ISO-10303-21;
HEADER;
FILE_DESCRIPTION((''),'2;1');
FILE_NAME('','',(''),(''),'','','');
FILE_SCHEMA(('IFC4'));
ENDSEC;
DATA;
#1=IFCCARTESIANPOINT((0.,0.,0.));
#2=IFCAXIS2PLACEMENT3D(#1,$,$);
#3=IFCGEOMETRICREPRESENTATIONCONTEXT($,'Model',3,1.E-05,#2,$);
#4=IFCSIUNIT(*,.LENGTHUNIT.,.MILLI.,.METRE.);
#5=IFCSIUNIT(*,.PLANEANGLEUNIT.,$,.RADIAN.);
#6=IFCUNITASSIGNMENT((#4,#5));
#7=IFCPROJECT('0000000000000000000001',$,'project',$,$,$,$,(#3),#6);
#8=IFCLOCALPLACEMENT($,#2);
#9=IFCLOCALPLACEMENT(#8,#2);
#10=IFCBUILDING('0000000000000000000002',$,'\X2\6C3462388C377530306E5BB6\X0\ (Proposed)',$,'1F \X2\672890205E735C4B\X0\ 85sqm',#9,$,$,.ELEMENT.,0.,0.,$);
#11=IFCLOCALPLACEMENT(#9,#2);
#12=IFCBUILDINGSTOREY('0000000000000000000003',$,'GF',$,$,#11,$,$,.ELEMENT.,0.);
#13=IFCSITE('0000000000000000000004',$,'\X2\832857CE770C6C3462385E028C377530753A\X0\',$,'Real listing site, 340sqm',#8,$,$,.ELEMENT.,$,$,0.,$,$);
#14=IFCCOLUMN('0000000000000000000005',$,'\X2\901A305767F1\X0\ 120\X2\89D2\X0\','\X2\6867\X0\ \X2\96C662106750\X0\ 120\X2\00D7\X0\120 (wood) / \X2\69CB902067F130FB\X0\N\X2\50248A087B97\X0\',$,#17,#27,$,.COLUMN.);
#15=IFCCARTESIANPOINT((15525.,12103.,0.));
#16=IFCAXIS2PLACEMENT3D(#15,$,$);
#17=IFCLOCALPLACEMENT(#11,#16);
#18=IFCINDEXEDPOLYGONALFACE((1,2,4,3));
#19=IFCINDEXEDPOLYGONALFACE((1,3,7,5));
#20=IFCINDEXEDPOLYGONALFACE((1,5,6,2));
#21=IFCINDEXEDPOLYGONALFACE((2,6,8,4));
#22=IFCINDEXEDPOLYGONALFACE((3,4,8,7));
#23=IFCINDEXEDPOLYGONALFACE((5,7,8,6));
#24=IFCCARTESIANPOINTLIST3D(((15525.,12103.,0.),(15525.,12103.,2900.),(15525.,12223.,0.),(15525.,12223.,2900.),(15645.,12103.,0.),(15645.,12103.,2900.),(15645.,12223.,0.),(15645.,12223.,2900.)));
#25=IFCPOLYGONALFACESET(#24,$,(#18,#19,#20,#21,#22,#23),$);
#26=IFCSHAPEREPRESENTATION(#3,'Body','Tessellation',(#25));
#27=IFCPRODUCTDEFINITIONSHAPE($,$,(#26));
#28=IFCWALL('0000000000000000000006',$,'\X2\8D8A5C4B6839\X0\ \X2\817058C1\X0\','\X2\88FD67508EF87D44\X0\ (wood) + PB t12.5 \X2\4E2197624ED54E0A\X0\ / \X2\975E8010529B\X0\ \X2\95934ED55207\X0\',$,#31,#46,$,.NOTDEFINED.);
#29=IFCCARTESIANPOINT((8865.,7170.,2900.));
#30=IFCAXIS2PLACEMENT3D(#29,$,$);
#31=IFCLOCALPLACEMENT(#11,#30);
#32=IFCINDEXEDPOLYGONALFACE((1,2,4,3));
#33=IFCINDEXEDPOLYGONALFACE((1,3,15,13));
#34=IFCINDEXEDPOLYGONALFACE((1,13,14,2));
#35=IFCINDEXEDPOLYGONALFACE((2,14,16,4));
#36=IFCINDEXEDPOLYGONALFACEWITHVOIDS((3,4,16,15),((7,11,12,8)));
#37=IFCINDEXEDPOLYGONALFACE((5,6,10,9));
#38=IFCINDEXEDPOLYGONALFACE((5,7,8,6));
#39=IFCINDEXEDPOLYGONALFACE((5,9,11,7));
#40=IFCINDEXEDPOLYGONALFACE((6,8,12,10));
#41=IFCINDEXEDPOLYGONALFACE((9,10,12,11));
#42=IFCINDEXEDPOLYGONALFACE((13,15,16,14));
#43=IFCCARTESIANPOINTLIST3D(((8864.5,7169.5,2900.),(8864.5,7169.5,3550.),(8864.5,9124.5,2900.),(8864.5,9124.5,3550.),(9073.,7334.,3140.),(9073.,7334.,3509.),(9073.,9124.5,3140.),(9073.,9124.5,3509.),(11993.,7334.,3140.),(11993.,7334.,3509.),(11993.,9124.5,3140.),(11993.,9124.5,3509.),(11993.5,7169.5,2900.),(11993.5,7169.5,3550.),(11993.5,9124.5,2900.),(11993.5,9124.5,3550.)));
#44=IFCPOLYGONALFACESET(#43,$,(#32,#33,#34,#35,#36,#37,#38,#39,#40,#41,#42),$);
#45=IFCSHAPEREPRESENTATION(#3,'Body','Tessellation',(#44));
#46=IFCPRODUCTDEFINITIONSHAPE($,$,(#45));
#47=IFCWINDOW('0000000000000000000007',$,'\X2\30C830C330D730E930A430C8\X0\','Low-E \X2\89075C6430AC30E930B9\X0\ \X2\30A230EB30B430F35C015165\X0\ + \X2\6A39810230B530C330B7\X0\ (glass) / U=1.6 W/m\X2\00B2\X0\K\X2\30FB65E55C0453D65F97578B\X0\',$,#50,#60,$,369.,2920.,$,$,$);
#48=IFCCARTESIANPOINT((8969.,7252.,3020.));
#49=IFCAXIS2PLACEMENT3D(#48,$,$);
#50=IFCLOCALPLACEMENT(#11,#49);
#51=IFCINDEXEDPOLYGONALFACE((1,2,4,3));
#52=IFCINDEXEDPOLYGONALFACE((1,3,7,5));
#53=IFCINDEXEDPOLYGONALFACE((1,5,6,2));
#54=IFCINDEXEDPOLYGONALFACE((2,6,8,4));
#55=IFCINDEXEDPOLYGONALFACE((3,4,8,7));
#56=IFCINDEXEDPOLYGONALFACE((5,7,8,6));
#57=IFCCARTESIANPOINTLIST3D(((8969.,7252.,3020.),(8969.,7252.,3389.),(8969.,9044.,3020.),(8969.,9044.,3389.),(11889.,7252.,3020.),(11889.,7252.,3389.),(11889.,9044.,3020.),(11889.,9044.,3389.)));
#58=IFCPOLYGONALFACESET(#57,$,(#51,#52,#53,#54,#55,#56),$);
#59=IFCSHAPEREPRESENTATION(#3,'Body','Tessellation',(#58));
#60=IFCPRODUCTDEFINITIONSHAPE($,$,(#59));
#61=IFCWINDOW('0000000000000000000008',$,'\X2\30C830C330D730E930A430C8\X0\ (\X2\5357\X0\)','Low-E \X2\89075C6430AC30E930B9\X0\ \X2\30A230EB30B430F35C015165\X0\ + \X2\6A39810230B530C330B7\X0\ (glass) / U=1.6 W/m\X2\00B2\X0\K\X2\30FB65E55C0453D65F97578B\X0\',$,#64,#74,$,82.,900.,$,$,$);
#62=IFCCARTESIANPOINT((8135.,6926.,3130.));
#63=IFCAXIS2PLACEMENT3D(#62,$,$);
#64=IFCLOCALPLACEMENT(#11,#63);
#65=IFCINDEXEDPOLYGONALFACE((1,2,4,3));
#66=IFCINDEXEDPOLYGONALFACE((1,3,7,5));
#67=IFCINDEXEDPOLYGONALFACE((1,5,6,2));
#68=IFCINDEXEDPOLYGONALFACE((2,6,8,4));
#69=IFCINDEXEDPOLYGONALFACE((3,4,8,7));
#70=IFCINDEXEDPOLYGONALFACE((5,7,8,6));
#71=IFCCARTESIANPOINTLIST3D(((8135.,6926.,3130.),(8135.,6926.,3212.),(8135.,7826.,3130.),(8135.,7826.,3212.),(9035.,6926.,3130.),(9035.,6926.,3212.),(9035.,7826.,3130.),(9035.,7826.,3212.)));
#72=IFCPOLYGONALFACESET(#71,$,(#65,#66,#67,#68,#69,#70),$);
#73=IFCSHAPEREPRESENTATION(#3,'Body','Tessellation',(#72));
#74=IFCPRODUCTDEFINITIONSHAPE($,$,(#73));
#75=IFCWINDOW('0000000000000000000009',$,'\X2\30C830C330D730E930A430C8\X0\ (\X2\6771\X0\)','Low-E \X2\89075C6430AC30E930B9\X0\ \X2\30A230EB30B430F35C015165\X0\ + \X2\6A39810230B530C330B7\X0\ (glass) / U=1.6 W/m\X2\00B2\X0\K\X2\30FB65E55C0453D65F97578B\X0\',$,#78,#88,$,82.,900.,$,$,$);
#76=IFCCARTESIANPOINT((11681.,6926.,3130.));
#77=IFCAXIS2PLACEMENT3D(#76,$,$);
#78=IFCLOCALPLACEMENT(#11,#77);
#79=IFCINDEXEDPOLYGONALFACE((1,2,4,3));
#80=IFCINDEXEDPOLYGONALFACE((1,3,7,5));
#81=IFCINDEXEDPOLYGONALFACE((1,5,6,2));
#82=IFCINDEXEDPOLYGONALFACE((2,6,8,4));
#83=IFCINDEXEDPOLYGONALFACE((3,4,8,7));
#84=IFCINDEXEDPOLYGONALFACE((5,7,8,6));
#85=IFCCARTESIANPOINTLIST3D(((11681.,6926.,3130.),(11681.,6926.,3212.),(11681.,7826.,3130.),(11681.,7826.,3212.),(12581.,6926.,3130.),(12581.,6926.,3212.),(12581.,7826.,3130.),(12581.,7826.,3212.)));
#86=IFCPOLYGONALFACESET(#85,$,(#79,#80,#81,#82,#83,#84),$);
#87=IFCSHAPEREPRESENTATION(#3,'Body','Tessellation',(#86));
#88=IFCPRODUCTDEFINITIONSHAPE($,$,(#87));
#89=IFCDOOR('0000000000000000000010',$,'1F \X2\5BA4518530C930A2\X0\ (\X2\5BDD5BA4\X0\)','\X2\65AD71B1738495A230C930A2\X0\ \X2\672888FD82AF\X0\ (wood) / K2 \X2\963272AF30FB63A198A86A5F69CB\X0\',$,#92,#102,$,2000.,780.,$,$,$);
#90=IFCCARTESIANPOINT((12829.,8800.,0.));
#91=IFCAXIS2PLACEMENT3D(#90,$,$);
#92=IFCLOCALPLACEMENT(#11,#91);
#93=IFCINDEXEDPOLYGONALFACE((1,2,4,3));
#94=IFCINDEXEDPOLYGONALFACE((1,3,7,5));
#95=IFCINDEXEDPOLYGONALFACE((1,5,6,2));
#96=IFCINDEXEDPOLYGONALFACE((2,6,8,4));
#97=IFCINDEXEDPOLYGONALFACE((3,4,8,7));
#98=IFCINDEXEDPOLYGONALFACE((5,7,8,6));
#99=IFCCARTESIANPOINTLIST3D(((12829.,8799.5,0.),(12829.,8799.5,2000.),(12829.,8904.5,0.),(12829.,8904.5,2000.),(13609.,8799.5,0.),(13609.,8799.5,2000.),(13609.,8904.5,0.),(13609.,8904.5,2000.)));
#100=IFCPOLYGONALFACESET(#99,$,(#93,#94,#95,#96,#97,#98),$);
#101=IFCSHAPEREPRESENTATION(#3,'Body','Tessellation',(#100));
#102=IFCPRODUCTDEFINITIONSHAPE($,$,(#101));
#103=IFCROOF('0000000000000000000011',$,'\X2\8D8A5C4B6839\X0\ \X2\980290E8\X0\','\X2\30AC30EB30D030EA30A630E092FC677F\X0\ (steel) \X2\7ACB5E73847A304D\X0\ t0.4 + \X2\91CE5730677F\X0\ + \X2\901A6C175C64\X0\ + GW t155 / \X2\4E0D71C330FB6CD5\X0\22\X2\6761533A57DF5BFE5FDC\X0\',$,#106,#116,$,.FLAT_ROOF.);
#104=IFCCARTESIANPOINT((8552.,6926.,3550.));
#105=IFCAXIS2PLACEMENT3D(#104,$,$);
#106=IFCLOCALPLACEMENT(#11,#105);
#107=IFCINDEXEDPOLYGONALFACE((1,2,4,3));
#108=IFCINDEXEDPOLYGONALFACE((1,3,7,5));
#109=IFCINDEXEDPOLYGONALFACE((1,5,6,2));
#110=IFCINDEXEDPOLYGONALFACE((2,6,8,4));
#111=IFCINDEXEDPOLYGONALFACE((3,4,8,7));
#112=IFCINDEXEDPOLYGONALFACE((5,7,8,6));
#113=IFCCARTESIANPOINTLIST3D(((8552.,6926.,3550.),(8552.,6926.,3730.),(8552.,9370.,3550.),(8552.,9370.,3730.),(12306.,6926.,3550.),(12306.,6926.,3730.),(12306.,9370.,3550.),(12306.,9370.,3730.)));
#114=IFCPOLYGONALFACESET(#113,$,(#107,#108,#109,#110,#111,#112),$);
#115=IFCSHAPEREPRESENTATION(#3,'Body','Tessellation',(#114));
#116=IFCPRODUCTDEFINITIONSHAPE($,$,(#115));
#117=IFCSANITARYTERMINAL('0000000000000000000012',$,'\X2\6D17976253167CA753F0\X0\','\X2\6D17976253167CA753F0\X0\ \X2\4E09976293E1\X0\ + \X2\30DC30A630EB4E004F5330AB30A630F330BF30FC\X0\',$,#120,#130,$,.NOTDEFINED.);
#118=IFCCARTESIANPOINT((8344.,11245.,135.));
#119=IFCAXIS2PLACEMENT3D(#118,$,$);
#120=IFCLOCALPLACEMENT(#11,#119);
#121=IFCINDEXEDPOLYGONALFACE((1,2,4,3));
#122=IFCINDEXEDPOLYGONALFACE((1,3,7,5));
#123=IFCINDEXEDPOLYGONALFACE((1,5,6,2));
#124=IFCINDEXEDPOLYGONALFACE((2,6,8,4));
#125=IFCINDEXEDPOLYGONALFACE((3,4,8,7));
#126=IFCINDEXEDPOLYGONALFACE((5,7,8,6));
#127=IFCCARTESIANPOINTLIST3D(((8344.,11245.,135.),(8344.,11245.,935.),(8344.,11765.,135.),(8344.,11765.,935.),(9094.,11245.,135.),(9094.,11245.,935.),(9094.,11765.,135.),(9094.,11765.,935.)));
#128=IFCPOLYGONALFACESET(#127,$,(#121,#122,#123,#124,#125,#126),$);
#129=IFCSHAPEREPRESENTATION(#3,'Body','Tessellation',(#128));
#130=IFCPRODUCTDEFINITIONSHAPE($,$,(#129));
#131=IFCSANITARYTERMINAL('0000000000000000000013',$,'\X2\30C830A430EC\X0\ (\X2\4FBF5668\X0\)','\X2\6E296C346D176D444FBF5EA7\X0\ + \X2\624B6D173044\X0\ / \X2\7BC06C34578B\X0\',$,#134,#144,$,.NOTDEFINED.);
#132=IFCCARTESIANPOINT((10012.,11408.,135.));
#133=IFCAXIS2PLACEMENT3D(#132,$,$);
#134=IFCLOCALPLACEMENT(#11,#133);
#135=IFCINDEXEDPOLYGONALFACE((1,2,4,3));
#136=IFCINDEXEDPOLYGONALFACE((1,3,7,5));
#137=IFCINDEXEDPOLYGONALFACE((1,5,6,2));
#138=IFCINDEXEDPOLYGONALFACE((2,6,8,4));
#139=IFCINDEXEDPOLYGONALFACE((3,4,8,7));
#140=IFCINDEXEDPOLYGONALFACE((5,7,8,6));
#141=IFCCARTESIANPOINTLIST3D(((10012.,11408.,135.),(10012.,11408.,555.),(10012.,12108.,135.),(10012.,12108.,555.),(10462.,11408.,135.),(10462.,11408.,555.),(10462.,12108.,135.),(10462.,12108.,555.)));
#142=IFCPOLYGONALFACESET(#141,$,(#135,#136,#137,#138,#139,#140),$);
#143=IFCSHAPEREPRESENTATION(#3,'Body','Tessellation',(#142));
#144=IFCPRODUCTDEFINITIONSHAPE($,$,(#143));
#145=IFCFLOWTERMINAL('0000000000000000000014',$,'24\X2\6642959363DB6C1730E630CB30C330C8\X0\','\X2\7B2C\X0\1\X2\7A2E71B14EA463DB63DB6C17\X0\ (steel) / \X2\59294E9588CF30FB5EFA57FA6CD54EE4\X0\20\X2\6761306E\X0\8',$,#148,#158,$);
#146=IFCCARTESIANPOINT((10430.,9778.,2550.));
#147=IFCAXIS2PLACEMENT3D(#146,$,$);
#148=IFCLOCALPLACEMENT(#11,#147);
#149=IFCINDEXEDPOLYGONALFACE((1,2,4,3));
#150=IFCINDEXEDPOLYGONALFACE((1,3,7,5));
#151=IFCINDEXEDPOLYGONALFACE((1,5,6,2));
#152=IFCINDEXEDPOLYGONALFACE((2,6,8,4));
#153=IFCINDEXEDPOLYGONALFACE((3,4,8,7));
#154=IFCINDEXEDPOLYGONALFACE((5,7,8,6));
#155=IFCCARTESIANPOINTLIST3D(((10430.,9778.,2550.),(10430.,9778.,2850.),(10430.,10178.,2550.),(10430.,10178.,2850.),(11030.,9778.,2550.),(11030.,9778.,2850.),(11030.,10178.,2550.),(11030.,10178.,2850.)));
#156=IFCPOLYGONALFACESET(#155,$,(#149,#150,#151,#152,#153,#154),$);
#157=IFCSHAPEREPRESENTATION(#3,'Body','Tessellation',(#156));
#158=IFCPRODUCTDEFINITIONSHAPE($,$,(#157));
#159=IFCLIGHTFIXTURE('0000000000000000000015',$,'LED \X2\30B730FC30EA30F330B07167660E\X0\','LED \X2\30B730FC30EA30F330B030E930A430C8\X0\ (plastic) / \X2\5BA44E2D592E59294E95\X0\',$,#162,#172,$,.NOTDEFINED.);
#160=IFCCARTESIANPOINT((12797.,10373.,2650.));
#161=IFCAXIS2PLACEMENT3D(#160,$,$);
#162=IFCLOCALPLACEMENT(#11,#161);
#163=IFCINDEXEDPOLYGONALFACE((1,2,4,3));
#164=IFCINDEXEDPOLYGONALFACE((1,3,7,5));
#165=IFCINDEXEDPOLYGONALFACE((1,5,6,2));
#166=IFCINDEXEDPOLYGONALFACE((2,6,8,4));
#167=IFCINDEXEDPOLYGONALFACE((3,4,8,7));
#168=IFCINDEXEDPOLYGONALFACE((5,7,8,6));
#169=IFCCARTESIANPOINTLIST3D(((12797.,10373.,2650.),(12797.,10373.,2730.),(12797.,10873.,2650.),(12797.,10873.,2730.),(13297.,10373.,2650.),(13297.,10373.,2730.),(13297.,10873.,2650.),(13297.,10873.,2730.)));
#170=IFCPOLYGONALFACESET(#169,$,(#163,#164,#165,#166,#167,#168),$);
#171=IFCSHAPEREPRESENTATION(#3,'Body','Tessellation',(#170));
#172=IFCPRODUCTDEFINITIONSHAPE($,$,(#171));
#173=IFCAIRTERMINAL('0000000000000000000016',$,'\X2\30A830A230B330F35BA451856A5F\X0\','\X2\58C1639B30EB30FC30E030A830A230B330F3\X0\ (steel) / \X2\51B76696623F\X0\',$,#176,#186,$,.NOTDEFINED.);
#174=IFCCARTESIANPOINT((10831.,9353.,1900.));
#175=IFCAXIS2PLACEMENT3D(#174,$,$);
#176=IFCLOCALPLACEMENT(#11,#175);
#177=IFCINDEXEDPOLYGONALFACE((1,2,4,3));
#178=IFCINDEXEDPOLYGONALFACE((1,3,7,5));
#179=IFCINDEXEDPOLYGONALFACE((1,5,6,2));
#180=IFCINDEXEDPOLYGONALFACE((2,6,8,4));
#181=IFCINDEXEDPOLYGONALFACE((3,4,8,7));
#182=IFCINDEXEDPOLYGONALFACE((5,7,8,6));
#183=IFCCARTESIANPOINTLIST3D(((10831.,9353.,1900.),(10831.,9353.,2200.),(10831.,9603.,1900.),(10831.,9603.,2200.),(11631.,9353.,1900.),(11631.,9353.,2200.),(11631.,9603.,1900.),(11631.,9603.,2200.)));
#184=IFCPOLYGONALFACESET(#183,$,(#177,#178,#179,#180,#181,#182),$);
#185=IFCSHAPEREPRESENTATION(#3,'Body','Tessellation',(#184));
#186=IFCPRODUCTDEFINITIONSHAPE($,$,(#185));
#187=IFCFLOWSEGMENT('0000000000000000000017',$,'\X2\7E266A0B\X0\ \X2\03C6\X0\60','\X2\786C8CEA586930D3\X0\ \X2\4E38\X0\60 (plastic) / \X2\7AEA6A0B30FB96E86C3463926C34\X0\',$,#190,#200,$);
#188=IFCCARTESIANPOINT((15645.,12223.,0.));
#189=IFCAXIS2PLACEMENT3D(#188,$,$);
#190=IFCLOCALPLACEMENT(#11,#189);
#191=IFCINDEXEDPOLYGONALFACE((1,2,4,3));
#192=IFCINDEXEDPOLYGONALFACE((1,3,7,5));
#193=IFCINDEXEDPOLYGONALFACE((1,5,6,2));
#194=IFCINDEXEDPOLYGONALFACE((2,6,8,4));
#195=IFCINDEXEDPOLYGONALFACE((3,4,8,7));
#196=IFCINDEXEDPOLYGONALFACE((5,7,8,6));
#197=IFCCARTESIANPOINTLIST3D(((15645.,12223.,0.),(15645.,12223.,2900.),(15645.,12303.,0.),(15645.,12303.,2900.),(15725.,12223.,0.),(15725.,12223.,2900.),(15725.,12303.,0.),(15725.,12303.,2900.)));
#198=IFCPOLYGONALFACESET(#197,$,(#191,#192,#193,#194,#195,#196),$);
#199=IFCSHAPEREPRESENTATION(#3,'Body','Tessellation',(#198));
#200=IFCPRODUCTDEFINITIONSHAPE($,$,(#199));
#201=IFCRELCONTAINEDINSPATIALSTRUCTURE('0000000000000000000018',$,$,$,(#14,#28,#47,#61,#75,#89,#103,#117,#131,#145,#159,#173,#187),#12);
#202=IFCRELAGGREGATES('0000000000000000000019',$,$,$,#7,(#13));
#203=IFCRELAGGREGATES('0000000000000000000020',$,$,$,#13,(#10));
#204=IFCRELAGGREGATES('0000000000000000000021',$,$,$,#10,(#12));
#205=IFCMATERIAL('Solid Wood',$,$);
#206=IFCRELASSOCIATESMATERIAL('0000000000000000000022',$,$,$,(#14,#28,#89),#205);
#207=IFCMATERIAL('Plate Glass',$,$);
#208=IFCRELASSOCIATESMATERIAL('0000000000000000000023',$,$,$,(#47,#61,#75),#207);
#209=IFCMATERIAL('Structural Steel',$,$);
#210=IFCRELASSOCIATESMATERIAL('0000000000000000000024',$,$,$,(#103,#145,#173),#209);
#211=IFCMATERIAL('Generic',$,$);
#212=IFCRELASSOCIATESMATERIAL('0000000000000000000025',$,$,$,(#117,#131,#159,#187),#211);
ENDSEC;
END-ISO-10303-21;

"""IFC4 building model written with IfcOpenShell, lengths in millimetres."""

from ifc_helpers import new_model, si_unit, frame, frame_2d, origin, place, context, project, spatial, rectangle, extrude, material, element, fill, save


model = new_model("IFC4")

# Units and contexts
model_context = context("Model", 3, precision=1e-05, world=origin())
ifc_project = project(units=[si_unit("LENGTHUNIT", "METRE", prefix="MILLI"), si_unit("PLANEANGLEUNIT", "RADIAN")], contexts=[model_context])

# Site, building, storey
site_placement = place(None, origin())
site = spatial("IfcSite", under=ifc_project, at=site_placement, Name="茨城県水戸市谷田町", ObjectType="Real listing site, 340sqm", CompositionType="ELEMENT", RefElevation=0.0)
building_placement = place(site_placement, origin())
building = spatial("IfcBuilding", under=site, at=building_placement, Name="水戸谷田の家 (Proposed)", ObjectType="1F 木造平屋 85sqm", CompositionType="ELEMENT", ElevationOfRefHeight=0.0, ElevationOfTerrain=0.0)
storey_placement = place(building_placement, origin())
storey = spatial("IfcBuildingStorey", under=building, at=storey_placement, Name="GF", CompositionType="ELEMENT", Elevation=0.0)

# Column
ifc_material_1 = material(Name="Solid Wood")
column_1_placement = place(storey_placement, frame((15525.0, 12103.0, 0.0)))
element("IfcColumn", 1, at=column_1_placement, inside=storey, material=ifc_material_1, Name="通し柱 120角", Description="桧 集成材 120×120 (wood) / 構造柱・N値計算", PredefinedType="COLUMN", context=model_context, shape_type="SweptSolid", body=[
    extrude(rectangle(XDim=120.0, YDim=120.0, at=frame_2d((60.0, 60.0))), frame((15525.0, 12103.0, 0.0)), (0.0, 0.0, 1.0), 2900.0),
])

# Wall, openings, windows
wall_1_placement = place(storey_placement, frame((8865.0, 7170.0, 2900.0)))
wall_1 = element("IfcWall", 2, at=wall_1_placement, inside=storey, material=ifc_material_1, Name="越屋根 腰壁", Description="製材軸組 (wood) + PB t12.5 両面仕上 / 非耐力 間仕切", PredefinedType="NOTDEFINED", context=model_context, shape_type="SweptSolid", body=[
    extrude(rectangle(XDim=3129.0, YDim=1955.0, at=frame_2d((1564.0, 977.0))), frame((8865.0, 7170.0, 2900.0)), (0.0, 0.0, 1.0), 650.0),
])
opening_1_placement = place(storey_placement, frame((8969.0, 7252.0, 3020.0)))
opening_1 = element("IfcOpeningElement", 3, at=opening_1_placement, cuts=wall_1, PredefinedType="NOTDEFINED", context=model_context, shape_type="SweptSolid", body=[
    extrude(rectangle(XDim=2920.0, YDim=1792.0, at=frame_2d((1460.0, 896.0))), frame((8969.0, 7252.0, 3020.0)), (0.0, 0.0, 1.0), 369.0),
])
opening_2_placement = place(storey_placement, frame((8135.0, 6926.0, 3130.0)))
opening_2 = element("IfcOpeningElement", 4, at=opening_2_placement, cuts=wall_1, PredefinedType="NOTDEFINED", context=model_context, shape_type="SweptSolid", body=[
    extrude(rectangle(XDim=900.0, YDim=900.0, at=frame_2d((450.0, 450.0))), frame((8135.0, 6926.0, 3130.0)), (0.0, 0.0, 1.0), 82.0),
])
opening_3_placement = place(storey_placement, frame((11681.0, 6926.0, 3130.0)))
opening_3 = element("IfcOpeningElement", 5, at=opening_3_placement, cuts=wall_1, PredefinedType="NOTDEFINED", context=model_context, shape_type="SweptSolid", body=[
    extrude(rectangle(XDim=900.0, YDim=900.0, at=frame_2d((450.0, 450.0))), frame((11681.0, 6926.0, 3130.0)), (0.0, 0.0, 1.0), 82.0),
])
ifc_material_2 = material(Name="Plate Glass")
window_1_placement = place(storey_placement, frame((8969.0, 7252.0, 3020.0)))
window_1 = element("IfcWindow", 6, at=window_1_placement, inside=storey, material=ifc_material_2, Name="トップライト", Description="Low-E 複層ガラス アルゴン封入 + 樹脂サッシ (glass) / U=1.6 W/m²K・日射取得型", OverallHeight=369.0, OverallWidth=2920.0, context=model_context, shape_type="SweptSolid", body=[
    extrude(rectangle(XDim=2920.0, YDim=1792.0, at=frame_2d((1460.0, 896.0))), frame((8969.0, 7252.0, 3020.0)), (0.0, 0.0, 1.0), 369.0),
])
fill(opening_1, window_1)
window_2_placement = place(storey_placement, frame((8135.0, 6926.0, 3130.0)))
window_2 = element("IfcWindow", 7, at=window_2_placement, inside=storey, material=ifc_material_2, Name="トップライト (南)", Description="Low-E 複層ガラス アルゴン封入 + 樹脂サッシ (glass) / U=1.6 W/m²K・日射取得型", OverallHeight=82.0, OverallWidth=900.0, context=model_context, shape_type="SweptSolid", body=[
    extrude(rectangle(XDim=900.0, YDim=900.0, at=frame_2d((450.0, 450.0))), frame((8135.0, 6926.0, 3130.0)), (0.0, 0.0, 1.0), 82.0),
])
fill(opening_2, window_2)
window_3_placement = place(storey_placement, frame((11681.0, 6926.0, 3130.0)))
window_3 = element("IfcWindow", 8, at=window_3_placement, inside=storey, material=ifc_material_2, Name="トップライト (東)", Description="Low-E 複層ガラス アルゴン封入 + 樹脂サッシ (glass) / U=1.6 W/m²K・日射取得型", OverallHeight=82.0, OverallWidth=900.0, context=model_context, shape_type="SweptSolid", body=[
    extrude(rectangle(XDim=900.0, YDim=900.0, at=frame_2d((450.0, 450.0))), frame((11681.0, 6926.0, 3130.0)), (0.0, 0.0, 1.0), 82.0),
])
fill(opening_3, window_3)

# Door
door_placement = place(storey_placement, frame((12829.0, 8800.0, 0.0)))
element("IfcDoor", 9, at=door_placement, inside=storey, material=ifc_material_1, Name="1F 室内ドア (寝室)", Description="断熱玄関ドア 木製芯 (wood) / K2 防犯・採風機構", OverallHeight=2000.0, OverallWidth=780.0, context=model_context, shape_type="SweptSolid", body=[
    extrude(rectangle(XDim=780.0, YDim=105.0, at=frame_2d((390.0, 52.0))), frame((12829.0, 8800.0, 0.0)), (0.0, 0.0, 1.0), 2000.0),
])

# Roof
ifc_material_3 = material(Name="Structural Steel")
roof_placement = place(storey_placement, frame((8552.0, 6926.0, 3550.0)))
element("IfcRoof", 10, at=roof_placement, inside=storey, material=ifc_material_3, Name="越屋根 頂部", Description="ガルバリウム鋼板 (steel) 立平葺き t0.4 + 野地板 + 通気層 + GW t155 / 不燃・法22条区域対応", PredefinedType="FLAT_ROOF", context=model_context, shape_type="SweptSolid", body=[
    extrude(rectangle(XDim=3754.0, YDim=2444.0, at=frame_2d((1877.0, 1222.0))), frame((8552.0, 6926.0, 3550.0)), (0.0, 0.0, 1.0), 180.0),
])

# Sanitary terminals
ifc_material_4 = material(Name="Generic")
sanitary_terminal_1_placement = place(storey_placement, frame((8344.0, 11245.0, 135.0)))
element("IfcSanitaryTerminal", 11, at=sanitary_terminal_1_placement, inside=storey, material=ifc_material_4, Name="洗面化粧台", Description="洗面化粧台 三面鏡 + ボウル一体カウンター", PredefinedType="NOTDEFINED", context=model_context, shape_type="SweptSolid", body=[
    extrude(rectangle(XDim=750.0, YDim=520.0, at=frame_2d((375.0, 260.0))), frame((8344.0, 11245.0, 135.0)), (0.0, 0.0, 1.0), 800.0),
])
sanitary_terminal_2_placement = place(storey_placement, frame((10012.0, 11408.0, 135.0)))
element("IfcSanitaryTerminal", 12, at=sanitary_terminal_2_placement, inside=storey, material=ifc_material_4, Name="トイレ (便器)", Description="温水洗浄便座 + 手洗い / 節水型", PredefinedType="NOTDEFINED", context=model_context, shape_type="SweptSolid", body=[
    extrude(rectangle(XDim=450.0, YDim=700.0, at=frame_2d((225.0, 350.0))), frame((10012.0, 11408.0, 135.0)), (0.0, 0.0, 1.0), 420.0),
])

# Flow terminal
flow_terminal_placement = place(storey_placement, frame((10430.0, 9778.0, 2550.0)))
element("IfcFlowTerminal", 13, at=flow_terminal_placement, inside=storey, material=ifc_material_3, Name="24時間換気ユニット", Description="第1種熱交換換気 (steel) / 天井裏・建基法令20条の8", context=model_context, shape_type="SweptSolid", body=[
    extrude(rectangle(XDim=600.0, YDim=400.0, at=frame_2d((300.0, 200.0))), frame((10430.0, 9778.0, 2550.0)), (0.0, 0.0, 1.0), 300.0),
])

# Light fixture
light_fixture_placement = place(storey_placement, frame((12797.0, 10373.0, 2650.0)))
element("IfcLightFixture", 14, at=light_fixture_placement, inside=storey, material=ifc_material_4, Name="LED シーリング照明", Description="LED シーリングライト (plastic) / 室中央天井", PredefinedType="NOTDEFINED", context=model_context, shape_type="SweptSolid", body=[
    extrude(rectangle(XDim=500.0, YDim=500.0, at=frame_2d((250.0, 250.0))), frame((12797.0, 10373.0, 2650.0)), (0.0, 0.0, 1.0), 80.0),
])

# Air terminal
air_terminal_placement = place(storey_placement, frame((10831.0, 9353.0, 1900.0)))
element("IfcAirTerminal", 15, at=air_terminal_placement, inside=storey, material=ifc_material_3, Name="エアコン室内機", Description="壁掛ルームエアコン (steel) / 冷暖房", PredefinedType="NOTDEFINED", context=model_context, shape_type="SweptSolid", body=[
    extrude(rectangle(XDim=800.0, YDim=250.0, at=frame_2d((400.0, 125.0))), frame((10831.0, 9353.0, 1900.0)), (0.0, 0.0, 1.0), 300.0),
])

# Flow segment
flow_segment_placement = place(storey_placement, frame((15645.0, 12223.0, 0.0)))
element("IfcFlowSegment", 16, at=flow_segment_placement, inside=storey, material=ifc_material_4, Name="縦樋 φ60", Description="硬質塩ビ 丸60 (plastic) / 竪樋・雨水排水", context=model_context, shape_type="SweptSolid", body=[
    extrude(rectangle(XDim=80.0, YDim=80.0, at=frame_2d((40.0, 40.0))), frame((15645.0, 12223.0, 0.0)), (0.0, 0.0, 1.0), 2900.0),
])

save(model, "model.ifc")
